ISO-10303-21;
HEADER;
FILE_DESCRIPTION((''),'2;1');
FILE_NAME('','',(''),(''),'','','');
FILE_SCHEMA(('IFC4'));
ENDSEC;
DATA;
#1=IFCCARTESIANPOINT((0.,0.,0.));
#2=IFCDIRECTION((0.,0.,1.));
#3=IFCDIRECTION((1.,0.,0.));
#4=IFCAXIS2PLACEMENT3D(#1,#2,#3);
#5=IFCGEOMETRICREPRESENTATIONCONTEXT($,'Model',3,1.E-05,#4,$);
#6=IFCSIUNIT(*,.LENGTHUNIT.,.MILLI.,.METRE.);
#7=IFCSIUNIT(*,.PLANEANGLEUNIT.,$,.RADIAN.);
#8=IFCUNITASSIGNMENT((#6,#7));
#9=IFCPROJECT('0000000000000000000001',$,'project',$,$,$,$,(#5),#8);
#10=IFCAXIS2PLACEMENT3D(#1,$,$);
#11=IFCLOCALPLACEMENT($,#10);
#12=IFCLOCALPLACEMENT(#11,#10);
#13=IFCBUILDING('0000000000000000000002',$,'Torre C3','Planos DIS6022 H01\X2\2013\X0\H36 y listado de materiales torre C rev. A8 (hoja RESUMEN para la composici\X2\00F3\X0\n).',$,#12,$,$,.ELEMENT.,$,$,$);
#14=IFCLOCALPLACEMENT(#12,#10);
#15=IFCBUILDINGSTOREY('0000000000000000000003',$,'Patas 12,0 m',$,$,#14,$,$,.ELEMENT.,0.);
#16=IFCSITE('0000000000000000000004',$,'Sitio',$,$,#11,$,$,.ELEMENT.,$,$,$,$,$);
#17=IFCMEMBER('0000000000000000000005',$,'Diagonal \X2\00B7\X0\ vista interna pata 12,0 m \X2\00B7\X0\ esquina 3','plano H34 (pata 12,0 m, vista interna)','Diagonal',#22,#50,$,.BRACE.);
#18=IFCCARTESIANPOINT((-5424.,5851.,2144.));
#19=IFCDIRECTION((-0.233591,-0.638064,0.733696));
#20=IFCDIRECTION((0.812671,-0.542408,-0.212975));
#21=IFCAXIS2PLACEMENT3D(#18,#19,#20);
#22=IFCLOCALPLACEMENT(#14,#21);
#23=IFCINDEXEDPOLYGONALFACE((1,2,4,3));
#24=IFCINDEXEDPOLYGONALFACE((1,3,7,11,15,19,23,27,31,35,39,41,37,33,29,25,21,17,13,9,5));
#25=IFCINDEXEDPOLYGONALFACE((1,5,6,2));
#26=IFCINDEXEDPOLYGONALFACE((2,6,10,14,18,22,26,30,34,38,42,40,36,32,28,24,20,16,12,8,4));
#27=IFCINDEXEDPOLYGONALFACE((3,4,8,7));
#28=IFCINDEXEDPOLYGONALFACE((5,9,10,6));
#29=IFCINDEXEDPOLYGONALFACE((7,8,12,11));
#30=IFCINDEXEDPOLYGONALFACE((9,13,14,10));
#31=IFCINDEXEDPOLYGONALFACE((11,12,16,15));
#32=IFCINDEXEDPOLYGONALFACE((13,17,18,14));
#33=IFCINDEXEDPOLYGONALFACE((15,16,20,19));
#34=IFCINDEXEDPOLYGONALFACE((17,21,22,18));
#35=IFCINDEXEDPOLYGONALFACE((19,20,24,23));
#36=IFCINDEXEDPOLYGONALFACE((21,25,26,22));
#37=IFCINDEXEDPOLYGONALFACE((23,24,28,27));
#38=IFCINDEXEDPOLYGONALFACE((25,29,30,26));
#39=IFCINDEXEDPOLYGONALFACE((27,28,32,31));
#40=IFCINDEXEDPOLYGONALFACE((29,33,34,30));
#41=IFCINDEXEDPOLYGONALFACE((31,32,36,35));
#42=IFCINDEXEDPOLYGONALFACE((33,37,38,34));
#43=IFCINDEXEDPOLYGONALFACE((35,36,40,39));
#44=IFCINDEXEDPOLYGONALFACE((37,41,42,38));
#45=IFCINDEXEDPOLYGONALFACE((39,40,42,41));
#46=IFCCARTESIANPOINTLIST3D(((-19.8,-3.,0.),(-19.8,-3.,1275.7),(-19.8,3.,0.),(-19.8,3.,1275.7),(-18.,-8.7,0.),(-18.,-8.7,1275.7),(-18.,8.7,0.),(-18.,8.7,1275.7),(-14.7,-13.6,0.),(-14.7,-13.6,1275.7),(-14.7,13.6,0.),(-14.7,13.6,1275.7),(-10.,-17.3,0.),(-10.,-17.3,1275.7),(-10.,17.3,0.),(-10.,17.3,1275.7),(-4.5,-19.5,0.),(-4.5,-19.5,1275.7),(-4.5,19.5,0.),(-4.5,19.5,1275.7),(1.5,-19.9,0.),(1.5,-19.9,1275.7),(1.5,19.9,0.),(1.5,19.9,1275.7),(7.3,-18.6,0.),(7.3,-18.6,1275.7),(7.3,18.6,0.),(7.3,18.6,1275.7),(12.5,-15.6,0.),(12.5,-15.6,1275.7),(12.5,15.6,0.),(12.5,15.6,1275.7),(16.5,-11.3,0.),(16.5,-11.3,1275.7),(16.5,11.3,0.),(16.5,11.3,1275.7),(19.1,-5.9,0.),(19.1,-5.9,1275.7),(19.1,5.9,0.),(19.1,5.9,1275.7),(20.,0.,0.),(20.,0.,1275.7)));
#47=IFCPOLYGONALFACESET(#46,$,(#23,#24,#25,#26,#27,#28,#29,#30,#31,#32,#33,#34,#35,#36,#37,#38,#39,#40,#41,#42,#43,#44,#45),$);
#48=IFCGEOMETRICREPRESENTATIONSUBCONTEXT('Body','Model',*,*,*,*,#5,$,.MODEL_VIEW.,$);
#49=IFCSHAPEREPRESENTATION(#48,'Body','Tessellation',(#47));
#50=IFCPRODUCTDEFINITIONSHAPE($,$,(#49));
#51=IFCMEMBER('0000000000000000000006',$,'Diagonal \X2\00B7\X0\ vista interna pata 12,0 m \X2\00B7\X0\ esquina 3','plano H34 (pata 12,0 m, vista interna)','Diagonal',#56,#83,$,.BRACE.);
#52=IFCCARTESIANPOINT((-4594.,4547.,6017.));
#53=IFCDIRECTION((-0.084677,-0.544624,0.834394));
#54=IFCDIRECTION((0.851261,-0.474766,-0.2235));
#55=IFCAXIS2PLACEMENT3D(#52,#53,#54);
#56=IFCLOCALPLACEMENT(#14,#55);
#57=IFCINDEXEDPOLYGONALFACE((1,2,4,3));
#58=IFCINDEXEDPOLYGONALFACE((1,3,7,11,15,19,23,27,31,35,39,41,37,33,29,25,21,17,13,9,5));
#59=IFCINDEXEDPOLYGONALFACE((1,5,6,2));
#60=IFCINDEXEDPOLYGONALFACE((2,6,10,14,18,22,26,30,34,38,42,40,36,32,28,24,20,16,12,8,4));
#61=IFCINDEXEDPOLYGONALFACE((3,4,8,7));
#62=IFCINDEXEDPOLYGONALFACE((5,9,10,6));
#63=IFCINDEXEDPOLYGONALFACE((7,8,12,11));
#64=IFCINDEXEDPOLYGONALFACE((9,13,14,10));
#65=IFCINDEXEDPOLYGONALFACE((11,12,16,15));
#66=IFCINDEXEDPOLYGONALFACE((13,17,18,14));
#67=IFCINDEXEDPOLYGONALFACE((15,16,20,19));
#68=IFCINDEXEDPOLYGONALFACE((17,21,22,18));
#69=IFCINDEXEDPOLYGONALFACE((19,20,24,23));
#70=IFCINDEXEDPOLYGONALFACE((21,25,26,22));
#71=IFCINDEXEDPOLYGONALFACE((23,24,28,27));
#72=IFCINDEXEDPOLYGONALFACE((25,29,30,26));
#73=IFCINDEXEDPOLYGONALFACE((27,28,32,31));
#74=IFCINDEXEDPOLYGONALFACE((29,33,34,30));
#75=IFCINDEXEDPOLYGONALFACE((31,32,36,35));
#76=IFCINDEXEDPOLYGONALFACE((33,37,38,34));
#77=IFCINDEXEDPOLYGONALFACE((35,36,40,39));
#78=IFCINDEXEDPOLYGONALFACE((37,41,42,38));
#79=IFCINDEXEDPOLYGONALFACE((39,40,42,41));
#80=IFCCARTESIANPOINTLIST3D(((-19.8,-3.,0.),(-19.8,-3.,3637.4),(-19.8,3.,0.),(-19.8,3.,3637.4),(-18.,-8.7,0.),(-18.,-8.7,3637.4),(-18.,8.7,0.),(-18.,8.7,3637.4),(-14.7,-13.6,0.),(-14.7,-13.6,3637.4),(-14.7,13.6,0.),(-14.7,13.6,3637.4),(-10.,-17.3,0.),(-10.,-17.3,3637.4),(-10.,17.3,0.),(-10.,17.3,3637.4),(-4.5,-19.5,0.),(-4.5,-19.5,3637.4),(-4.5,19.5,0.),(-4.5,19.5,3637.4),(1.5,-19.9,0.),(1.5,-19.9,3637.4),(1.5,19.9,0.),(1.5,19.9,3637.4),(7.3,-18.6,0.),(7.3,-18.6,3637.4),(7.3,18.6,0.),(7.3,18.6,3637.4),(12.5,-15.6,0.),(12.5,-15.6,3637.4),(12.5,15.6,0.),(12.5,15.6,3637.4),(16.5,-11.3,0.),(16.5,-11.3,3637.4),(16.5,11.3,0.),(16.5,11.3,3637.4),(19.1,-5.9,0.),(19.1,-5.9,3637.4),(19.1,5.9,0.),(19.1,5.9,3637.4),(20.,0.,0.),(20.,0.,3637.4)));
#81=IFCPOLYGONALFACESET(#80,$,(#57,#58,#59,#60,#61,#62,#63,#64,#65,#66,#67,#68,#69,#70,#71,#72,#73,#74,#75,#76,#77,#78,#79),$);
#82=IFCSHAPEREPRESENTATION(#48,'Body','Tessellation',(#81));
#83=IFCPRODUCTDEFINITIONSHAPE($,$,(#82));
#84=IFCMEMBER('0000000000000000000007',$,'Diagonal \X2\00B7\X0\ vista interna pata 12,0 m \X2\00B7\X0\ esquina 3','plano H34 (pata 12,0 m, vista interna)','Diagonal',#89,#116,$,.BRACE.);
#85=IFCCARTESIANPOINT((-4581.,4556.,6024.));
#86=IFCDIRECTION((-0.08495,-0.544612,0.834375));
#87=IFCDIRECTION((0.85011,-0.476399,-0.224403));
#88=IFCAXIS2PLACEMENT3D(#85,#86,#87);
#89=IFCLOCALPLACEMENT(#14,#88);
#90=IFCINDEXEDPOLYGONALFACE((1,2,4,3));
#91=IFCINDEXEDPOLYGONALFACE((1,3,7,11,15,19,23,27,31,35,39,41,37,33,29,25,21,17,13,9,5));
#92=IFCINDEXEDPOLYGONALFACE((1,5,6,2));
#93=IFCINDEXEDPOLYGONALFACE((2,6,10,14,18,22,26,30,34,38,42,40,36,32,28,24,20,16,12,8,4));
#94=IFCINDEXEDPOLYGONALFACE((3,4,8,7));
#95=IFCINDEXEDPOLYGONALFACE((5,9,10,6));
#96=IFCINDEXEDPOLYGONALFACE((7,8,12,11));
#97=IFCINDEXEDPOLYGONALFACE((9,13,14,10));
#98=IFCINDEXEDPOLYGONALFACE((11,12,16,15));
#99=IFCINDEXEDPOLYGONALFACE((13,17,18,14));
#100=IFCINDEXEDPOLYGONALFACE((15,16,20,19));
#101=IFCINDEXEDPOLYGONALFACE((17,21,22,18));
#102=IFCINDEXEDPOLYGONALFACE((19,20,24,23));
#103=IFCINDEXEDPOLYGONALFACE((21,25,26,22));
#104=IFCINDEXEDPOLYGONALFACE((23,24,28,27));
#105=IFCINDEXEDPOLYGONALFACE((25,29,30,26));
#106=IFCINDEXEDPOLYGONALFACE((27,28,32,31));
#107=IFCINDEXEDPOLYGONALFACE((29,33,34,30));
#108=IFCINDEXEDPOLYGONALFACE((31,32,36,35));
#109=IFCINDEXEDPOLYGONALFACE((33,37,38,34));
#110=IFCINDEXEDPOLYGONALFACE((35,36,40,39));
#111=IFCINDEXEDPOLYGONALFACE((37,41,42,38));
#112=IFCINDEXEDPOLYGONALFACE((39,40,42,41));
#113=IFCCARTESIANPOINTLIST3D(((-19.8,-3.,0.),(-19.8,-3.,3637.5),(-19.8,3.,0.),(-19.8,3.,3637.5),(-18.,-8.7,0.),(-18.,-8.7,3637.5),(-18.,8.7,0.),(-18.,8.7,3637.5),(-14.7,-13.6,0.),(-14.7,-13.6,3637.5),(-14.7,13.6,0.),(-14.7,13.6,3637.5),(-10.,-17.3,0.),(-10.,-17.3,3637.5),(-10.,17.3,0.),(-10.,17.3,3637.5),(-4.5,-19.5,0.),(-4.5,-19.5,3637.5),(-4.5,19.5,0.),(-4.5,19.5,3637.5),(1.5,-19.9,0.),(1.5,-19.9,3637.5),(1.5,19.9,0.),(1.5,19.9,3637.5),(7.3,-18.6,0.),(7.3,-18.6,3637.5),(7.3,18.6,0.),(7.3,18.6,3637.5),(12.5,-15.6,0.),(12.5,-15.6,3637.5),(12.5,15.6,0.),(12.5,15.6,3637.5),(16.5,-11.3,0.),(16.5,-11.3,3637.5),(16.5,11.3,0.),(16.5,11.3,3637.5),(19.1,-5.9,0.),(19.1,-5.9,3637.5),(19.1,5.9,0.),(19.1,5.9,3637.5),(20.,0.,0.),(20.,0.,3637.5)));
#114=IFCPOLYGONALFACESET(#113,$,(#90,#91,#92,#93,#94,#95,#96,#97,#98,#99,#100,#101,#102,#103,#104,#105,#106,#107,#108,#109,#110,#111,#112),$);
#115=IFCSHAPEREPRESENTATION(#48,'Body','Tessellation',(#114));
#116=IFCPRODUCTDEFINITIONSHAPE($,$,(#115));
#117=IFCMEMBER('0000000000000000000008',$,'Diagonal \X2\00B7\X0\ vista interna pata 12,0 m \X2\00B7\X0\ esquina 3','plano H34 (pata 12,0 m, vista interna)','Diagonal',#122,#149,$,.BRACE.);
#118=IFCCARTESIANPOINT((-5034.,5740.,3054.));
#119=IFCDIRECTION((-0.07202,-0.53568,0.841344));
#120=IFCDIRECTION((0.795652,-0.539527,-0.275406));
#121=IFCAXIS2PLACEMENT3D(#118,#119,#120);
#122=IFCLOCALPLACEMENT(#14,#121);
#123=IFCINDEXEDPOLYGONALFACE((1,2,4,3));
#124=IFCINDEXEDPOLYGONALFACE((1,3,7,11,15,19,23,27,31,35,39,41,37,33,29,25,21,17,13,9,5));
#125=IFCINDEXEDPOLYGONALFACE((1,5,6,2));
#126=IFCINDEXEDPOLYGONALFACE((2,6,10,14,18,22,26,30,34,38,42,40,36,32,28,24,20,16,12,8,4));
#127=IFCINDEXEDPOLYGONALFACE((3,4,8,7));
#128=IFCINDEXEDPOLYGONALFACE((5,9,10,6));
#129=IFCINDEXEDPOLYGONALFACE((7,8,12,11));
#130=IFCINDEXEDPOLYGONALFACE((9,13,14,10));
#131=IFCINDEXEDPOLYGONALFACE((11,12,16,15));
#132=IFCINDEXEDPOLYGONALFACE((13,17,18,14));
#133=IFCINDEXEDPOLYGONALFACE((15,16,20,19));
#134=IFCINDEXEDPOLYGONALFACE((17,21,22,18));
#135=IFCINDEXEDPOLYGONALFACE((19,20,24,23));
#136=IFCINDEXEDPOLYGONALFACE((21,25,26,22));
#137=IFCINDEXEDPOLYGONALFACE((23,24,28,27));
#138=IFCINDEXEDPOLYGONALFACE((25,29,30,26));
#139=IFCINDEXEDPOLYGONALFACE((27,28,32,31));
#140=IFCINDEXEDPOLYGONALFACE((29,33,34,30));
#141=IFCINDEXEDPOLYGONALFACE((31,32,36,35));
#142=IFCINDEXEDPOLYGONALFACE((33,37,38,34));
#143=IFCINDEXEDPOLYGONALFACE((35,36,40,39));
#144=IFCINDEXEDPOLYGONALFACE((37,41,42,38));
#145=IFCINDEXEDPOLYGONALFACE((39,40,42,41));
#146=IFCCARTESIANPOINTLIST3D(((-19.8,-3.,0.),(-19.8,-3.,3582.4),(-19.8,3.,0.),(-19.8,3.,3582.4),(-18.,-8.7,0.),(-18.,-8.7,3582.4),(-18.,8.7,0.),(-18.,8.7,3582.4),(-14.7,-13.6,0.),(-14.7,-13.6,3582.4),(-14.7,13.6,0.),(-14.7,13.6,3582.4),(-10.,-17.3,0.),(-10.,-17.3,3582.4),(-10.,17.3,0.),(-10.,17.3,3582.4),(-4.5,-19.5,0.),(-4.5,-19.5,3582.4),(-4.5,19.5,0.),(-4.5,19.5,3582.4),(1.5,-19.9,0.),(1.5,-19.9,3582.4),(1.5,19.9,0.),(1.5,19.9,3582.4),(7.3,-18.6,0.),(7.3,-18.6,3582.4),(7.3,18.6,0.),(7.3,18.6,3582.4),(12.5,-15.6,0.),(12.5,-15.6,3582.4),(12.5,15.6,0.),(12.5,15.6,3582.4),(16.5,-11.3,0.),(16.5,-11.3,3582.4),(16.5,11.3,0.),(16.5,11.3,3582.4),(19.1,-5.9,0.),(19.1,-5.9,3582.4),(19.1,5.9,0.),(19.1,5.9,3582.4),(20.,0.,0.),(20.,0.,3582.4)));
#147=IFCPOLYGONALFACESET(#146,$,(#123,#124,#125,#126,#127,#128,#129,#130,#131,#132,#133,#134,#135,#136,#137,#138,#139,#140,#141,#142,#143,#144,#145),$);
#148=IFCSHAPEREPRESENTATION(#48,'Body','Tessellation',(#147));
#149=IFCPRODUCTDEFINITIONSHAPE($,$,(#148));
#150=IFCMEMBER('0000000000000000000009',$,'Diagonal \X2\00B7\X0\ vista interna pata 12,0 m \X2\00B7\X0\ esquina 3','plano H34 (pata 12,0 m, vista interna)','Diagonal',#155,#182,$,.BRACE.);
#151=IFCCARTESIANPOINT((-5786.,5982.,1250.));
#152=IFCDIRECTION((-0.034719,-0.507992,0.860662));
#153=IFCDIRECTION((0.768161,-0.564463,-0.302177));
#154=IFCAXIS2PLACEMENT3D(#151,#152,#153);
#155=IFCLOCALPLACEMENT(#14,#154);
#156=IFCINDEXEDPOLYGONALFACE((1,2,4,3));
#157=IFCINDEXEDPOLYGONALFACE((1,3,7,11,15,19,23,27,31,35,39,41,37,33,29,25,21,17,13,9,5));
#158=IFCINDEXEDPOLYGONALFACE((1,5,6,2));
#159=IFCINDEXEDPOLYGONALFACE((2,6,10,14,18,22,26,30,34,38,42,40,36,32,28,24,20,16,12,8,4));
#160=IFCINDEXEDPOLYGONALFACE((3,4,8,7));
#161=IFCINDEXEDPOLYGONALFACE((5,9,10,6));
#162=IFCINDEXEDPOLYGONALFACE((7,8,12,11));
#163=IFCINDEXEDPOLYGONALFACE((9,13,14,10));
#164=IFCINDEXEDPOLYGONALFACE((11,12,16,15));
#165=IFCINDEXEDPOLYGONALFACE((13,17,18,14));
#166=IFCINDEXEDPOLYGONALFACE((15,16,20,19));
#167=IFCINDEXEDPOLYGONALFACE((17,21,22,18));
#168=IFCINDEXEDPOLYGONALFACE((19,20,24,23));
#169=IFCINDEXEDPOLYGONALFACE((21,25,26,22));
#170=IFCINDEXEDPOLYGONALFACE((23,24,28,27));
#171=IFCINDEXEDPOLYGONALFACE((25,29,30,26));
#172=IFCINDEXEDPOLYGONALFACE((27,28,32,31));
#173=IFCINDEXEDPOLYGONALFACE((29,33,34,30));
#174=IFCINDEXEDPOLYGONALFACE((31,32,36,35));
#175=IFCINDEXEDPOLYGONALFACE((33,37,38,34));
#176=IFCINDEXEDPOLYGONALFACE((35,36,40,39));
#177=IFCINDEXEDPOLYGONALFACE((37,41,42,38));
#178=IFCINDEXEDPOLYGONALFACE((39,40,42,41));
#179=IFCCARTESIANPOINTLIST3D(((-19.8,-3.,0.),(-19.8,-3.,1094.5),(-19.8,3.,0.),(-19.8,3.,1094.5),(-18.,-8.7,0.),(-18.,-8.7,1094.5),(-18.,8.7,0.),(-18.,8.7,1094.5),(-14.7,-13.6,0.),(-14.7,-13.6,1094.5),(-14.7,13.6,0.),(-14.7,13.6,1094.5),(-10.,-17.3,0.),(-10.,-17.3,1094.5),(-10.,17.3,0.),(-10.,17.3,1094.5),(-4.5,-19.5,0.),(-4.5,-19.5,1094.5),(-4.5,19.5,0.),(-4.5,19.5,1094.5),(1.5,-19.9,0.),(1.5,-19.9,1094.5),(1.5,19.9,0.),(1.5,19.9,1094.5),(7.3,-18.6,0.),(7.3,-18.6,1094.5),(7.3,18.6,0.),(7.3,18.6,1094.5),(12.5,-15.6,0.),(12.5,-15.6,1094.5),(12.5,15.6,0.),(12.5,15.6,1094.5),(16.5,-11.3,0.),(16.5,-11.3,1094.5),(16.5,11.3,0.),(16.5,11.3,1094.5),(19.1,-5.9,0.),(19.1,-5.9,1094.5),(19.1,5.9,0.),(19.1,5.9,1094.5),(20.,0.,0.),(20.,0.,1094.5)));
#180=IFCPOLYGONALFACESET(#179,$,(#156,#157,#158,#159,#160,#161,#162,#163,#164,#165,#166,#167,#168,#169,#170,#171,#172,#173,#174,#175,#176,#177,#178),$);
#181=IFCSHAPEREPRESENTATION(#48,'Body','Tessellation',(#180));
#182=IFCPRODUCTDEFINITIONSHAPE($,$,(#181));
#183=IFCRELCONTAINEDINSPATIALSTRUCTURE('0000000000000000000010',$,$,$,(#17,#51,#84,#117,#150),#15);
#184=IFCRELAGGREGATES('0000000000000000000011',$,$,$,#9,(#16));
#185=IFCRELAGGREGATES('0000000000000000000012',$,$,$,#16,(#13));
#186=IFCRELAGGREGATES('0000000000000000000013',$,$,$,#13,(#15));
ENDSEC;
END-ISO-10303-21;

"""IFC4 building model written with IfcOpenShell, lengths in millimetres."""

from ifc_helpers import new_model, si_unit, frame, origin, origin_with_axes, place, context, subcontext, project, spatial, circle, extrude, element, save


model = new_model("IFC4")

# Units and contexts
model_context = context("Model", 3, precision=1e-05, world=origin_with_axes())
body_context = subcontext(model_context, "Body", "Model", "MODEL_VIEW")
ifc_project = project(units=[si_unit("LENGTHUNIT", "METRE", prefix="MILLI"), si_unit("PLANEANGLEUNIT", "RADIAN")], contexts=[model_context])

# Site, building, storey
site_placement = place(None, origin())
site = spatial("IfcSite", under=ifc_project, at=site_placement, Name="Sitio", CompositionType="ELEMENT")
building_placement = place(site_placement, origin())
building = spatial("IfcBuilding", under=site, at=building_placement, Name="Torre C3", Description="Planos DIS6022 H01–H36 y listado de materiales torre C rev. A8 (hoja RESUMEN para la composición).", CompositionType="ELEMENT")
storey_placement = place(building_placement, origin())
storey = spatial("IfcBuildingStorey", under=building, at=storey_placement, Name="Patas 12,0 m", CompositionType="ELEMENT", Elevation=0.0)

# Members
member_1_placement = place(storey_placement, frame((-5424.0, 5851.0, 2144.0), z_axis=(-0.233591, -0.638064, 0.733696), x_axis=(0.812671, -0.542408, -0.212975)))
element("IfcMember", 1, at=member_1_placement, inside=storey, Name="Diagonal · vista interna pata 12,0 m · esquina 3", Description="plano H34 (pata 12,0 m, vista interna)", ObjectType="Diagonal", PredefinedType="BRACE", context=body_context, shape_type="SweptSolid", body=[
    extrude(circle(Radius=20.0), None, (0.0, 0.0, 1.0), 1275.7),
])
member_2_placement = place(storey_placement, frame((-4594.0, 4547.0, 6017.0), z_axis=(-0.084677, -0.544624, 0.834394), x_axis=(0.851261, -0.474766, -0.2235)))
element("IfcMember", 2, at=member_2_placement, inside=storey, Name="Diagonal · vista interna pata 12,0 m · esquina 3", Description="plano H34 (pata 12,0 m, vista interna)", ObjectType="Diagonal", PredefinedType="BRACE", context=body_context, shape_type="SweptSolid", body=[
    extrude(circle(Radius=20.0), None, (0.0, 0.0, 1.0), 3637.4),
])
member_3_placement = place(storey_placement, frame((-4581.0, 4556.0, 6024.0), z_axis=(-0.08495, -0.544612, 0.834375), x_axis=(0.85011, -0.476399, -0.224403)))
element("IfcMember", 3, at=member_3_placement, inside=storey, Name="Diagonal · vista interna pata 12,0 m · esquina 3", Description="plano H34 (pata 12,0 m, vista interna)", ObjectType="Diagonal", PredefinedType="BRACE", context=body_context, shape_type="SweptSolid", body=[
    extrude(circle(Radius=20.0), None, (0.0, 0.0, 1.0), 3637.5),
])
member_4_placement = place(storey_placement, frame((-5034.0, 5740.0, 3054.0), z_axis=(-0.07202, -0.53568, 0.841344), x_axis=(0.795652, -0.539527, -0.275406)))
element("IfcMember", 4, at=member_4_placement, inside=storey, Name="Diagonal · vista interna pata 12,0 m · esquina 3", Description="plano H34 (pata 12,0 m, vista interna)", ObjectType="Diagonal", PredefinedType="BRACE", context=body_context, shape_type="SweptSolid", body=[
    extrude(circle(Radius=20.0), None, (0.0, 0.0, 1.0), 3582.4),
])
member_5_placement = place(storey_placement, frame((-5786.0, 5982.0, 1250.0), z_axis=(-0.034719, -0.507992, 0.860662), x_axis=(0.768161, -0.564463, -0.302177)))
element("IfcMember", 5, at=member_5_placement, inside=storey, Name="Diagonal · vista interna pata 12,0 m · esquina 3", Description="plano H34 (pata 12,0 m, vista interna)", ObjectType="Diagonal", PredefinedType="BRACE", context=body_context, shape_type="SweptSolid", body=[
    extrude(circle(Radius=20.0), None, (0.0, 0.0, 1.0), 1094.5),
])

save(model, "model.ifc")
